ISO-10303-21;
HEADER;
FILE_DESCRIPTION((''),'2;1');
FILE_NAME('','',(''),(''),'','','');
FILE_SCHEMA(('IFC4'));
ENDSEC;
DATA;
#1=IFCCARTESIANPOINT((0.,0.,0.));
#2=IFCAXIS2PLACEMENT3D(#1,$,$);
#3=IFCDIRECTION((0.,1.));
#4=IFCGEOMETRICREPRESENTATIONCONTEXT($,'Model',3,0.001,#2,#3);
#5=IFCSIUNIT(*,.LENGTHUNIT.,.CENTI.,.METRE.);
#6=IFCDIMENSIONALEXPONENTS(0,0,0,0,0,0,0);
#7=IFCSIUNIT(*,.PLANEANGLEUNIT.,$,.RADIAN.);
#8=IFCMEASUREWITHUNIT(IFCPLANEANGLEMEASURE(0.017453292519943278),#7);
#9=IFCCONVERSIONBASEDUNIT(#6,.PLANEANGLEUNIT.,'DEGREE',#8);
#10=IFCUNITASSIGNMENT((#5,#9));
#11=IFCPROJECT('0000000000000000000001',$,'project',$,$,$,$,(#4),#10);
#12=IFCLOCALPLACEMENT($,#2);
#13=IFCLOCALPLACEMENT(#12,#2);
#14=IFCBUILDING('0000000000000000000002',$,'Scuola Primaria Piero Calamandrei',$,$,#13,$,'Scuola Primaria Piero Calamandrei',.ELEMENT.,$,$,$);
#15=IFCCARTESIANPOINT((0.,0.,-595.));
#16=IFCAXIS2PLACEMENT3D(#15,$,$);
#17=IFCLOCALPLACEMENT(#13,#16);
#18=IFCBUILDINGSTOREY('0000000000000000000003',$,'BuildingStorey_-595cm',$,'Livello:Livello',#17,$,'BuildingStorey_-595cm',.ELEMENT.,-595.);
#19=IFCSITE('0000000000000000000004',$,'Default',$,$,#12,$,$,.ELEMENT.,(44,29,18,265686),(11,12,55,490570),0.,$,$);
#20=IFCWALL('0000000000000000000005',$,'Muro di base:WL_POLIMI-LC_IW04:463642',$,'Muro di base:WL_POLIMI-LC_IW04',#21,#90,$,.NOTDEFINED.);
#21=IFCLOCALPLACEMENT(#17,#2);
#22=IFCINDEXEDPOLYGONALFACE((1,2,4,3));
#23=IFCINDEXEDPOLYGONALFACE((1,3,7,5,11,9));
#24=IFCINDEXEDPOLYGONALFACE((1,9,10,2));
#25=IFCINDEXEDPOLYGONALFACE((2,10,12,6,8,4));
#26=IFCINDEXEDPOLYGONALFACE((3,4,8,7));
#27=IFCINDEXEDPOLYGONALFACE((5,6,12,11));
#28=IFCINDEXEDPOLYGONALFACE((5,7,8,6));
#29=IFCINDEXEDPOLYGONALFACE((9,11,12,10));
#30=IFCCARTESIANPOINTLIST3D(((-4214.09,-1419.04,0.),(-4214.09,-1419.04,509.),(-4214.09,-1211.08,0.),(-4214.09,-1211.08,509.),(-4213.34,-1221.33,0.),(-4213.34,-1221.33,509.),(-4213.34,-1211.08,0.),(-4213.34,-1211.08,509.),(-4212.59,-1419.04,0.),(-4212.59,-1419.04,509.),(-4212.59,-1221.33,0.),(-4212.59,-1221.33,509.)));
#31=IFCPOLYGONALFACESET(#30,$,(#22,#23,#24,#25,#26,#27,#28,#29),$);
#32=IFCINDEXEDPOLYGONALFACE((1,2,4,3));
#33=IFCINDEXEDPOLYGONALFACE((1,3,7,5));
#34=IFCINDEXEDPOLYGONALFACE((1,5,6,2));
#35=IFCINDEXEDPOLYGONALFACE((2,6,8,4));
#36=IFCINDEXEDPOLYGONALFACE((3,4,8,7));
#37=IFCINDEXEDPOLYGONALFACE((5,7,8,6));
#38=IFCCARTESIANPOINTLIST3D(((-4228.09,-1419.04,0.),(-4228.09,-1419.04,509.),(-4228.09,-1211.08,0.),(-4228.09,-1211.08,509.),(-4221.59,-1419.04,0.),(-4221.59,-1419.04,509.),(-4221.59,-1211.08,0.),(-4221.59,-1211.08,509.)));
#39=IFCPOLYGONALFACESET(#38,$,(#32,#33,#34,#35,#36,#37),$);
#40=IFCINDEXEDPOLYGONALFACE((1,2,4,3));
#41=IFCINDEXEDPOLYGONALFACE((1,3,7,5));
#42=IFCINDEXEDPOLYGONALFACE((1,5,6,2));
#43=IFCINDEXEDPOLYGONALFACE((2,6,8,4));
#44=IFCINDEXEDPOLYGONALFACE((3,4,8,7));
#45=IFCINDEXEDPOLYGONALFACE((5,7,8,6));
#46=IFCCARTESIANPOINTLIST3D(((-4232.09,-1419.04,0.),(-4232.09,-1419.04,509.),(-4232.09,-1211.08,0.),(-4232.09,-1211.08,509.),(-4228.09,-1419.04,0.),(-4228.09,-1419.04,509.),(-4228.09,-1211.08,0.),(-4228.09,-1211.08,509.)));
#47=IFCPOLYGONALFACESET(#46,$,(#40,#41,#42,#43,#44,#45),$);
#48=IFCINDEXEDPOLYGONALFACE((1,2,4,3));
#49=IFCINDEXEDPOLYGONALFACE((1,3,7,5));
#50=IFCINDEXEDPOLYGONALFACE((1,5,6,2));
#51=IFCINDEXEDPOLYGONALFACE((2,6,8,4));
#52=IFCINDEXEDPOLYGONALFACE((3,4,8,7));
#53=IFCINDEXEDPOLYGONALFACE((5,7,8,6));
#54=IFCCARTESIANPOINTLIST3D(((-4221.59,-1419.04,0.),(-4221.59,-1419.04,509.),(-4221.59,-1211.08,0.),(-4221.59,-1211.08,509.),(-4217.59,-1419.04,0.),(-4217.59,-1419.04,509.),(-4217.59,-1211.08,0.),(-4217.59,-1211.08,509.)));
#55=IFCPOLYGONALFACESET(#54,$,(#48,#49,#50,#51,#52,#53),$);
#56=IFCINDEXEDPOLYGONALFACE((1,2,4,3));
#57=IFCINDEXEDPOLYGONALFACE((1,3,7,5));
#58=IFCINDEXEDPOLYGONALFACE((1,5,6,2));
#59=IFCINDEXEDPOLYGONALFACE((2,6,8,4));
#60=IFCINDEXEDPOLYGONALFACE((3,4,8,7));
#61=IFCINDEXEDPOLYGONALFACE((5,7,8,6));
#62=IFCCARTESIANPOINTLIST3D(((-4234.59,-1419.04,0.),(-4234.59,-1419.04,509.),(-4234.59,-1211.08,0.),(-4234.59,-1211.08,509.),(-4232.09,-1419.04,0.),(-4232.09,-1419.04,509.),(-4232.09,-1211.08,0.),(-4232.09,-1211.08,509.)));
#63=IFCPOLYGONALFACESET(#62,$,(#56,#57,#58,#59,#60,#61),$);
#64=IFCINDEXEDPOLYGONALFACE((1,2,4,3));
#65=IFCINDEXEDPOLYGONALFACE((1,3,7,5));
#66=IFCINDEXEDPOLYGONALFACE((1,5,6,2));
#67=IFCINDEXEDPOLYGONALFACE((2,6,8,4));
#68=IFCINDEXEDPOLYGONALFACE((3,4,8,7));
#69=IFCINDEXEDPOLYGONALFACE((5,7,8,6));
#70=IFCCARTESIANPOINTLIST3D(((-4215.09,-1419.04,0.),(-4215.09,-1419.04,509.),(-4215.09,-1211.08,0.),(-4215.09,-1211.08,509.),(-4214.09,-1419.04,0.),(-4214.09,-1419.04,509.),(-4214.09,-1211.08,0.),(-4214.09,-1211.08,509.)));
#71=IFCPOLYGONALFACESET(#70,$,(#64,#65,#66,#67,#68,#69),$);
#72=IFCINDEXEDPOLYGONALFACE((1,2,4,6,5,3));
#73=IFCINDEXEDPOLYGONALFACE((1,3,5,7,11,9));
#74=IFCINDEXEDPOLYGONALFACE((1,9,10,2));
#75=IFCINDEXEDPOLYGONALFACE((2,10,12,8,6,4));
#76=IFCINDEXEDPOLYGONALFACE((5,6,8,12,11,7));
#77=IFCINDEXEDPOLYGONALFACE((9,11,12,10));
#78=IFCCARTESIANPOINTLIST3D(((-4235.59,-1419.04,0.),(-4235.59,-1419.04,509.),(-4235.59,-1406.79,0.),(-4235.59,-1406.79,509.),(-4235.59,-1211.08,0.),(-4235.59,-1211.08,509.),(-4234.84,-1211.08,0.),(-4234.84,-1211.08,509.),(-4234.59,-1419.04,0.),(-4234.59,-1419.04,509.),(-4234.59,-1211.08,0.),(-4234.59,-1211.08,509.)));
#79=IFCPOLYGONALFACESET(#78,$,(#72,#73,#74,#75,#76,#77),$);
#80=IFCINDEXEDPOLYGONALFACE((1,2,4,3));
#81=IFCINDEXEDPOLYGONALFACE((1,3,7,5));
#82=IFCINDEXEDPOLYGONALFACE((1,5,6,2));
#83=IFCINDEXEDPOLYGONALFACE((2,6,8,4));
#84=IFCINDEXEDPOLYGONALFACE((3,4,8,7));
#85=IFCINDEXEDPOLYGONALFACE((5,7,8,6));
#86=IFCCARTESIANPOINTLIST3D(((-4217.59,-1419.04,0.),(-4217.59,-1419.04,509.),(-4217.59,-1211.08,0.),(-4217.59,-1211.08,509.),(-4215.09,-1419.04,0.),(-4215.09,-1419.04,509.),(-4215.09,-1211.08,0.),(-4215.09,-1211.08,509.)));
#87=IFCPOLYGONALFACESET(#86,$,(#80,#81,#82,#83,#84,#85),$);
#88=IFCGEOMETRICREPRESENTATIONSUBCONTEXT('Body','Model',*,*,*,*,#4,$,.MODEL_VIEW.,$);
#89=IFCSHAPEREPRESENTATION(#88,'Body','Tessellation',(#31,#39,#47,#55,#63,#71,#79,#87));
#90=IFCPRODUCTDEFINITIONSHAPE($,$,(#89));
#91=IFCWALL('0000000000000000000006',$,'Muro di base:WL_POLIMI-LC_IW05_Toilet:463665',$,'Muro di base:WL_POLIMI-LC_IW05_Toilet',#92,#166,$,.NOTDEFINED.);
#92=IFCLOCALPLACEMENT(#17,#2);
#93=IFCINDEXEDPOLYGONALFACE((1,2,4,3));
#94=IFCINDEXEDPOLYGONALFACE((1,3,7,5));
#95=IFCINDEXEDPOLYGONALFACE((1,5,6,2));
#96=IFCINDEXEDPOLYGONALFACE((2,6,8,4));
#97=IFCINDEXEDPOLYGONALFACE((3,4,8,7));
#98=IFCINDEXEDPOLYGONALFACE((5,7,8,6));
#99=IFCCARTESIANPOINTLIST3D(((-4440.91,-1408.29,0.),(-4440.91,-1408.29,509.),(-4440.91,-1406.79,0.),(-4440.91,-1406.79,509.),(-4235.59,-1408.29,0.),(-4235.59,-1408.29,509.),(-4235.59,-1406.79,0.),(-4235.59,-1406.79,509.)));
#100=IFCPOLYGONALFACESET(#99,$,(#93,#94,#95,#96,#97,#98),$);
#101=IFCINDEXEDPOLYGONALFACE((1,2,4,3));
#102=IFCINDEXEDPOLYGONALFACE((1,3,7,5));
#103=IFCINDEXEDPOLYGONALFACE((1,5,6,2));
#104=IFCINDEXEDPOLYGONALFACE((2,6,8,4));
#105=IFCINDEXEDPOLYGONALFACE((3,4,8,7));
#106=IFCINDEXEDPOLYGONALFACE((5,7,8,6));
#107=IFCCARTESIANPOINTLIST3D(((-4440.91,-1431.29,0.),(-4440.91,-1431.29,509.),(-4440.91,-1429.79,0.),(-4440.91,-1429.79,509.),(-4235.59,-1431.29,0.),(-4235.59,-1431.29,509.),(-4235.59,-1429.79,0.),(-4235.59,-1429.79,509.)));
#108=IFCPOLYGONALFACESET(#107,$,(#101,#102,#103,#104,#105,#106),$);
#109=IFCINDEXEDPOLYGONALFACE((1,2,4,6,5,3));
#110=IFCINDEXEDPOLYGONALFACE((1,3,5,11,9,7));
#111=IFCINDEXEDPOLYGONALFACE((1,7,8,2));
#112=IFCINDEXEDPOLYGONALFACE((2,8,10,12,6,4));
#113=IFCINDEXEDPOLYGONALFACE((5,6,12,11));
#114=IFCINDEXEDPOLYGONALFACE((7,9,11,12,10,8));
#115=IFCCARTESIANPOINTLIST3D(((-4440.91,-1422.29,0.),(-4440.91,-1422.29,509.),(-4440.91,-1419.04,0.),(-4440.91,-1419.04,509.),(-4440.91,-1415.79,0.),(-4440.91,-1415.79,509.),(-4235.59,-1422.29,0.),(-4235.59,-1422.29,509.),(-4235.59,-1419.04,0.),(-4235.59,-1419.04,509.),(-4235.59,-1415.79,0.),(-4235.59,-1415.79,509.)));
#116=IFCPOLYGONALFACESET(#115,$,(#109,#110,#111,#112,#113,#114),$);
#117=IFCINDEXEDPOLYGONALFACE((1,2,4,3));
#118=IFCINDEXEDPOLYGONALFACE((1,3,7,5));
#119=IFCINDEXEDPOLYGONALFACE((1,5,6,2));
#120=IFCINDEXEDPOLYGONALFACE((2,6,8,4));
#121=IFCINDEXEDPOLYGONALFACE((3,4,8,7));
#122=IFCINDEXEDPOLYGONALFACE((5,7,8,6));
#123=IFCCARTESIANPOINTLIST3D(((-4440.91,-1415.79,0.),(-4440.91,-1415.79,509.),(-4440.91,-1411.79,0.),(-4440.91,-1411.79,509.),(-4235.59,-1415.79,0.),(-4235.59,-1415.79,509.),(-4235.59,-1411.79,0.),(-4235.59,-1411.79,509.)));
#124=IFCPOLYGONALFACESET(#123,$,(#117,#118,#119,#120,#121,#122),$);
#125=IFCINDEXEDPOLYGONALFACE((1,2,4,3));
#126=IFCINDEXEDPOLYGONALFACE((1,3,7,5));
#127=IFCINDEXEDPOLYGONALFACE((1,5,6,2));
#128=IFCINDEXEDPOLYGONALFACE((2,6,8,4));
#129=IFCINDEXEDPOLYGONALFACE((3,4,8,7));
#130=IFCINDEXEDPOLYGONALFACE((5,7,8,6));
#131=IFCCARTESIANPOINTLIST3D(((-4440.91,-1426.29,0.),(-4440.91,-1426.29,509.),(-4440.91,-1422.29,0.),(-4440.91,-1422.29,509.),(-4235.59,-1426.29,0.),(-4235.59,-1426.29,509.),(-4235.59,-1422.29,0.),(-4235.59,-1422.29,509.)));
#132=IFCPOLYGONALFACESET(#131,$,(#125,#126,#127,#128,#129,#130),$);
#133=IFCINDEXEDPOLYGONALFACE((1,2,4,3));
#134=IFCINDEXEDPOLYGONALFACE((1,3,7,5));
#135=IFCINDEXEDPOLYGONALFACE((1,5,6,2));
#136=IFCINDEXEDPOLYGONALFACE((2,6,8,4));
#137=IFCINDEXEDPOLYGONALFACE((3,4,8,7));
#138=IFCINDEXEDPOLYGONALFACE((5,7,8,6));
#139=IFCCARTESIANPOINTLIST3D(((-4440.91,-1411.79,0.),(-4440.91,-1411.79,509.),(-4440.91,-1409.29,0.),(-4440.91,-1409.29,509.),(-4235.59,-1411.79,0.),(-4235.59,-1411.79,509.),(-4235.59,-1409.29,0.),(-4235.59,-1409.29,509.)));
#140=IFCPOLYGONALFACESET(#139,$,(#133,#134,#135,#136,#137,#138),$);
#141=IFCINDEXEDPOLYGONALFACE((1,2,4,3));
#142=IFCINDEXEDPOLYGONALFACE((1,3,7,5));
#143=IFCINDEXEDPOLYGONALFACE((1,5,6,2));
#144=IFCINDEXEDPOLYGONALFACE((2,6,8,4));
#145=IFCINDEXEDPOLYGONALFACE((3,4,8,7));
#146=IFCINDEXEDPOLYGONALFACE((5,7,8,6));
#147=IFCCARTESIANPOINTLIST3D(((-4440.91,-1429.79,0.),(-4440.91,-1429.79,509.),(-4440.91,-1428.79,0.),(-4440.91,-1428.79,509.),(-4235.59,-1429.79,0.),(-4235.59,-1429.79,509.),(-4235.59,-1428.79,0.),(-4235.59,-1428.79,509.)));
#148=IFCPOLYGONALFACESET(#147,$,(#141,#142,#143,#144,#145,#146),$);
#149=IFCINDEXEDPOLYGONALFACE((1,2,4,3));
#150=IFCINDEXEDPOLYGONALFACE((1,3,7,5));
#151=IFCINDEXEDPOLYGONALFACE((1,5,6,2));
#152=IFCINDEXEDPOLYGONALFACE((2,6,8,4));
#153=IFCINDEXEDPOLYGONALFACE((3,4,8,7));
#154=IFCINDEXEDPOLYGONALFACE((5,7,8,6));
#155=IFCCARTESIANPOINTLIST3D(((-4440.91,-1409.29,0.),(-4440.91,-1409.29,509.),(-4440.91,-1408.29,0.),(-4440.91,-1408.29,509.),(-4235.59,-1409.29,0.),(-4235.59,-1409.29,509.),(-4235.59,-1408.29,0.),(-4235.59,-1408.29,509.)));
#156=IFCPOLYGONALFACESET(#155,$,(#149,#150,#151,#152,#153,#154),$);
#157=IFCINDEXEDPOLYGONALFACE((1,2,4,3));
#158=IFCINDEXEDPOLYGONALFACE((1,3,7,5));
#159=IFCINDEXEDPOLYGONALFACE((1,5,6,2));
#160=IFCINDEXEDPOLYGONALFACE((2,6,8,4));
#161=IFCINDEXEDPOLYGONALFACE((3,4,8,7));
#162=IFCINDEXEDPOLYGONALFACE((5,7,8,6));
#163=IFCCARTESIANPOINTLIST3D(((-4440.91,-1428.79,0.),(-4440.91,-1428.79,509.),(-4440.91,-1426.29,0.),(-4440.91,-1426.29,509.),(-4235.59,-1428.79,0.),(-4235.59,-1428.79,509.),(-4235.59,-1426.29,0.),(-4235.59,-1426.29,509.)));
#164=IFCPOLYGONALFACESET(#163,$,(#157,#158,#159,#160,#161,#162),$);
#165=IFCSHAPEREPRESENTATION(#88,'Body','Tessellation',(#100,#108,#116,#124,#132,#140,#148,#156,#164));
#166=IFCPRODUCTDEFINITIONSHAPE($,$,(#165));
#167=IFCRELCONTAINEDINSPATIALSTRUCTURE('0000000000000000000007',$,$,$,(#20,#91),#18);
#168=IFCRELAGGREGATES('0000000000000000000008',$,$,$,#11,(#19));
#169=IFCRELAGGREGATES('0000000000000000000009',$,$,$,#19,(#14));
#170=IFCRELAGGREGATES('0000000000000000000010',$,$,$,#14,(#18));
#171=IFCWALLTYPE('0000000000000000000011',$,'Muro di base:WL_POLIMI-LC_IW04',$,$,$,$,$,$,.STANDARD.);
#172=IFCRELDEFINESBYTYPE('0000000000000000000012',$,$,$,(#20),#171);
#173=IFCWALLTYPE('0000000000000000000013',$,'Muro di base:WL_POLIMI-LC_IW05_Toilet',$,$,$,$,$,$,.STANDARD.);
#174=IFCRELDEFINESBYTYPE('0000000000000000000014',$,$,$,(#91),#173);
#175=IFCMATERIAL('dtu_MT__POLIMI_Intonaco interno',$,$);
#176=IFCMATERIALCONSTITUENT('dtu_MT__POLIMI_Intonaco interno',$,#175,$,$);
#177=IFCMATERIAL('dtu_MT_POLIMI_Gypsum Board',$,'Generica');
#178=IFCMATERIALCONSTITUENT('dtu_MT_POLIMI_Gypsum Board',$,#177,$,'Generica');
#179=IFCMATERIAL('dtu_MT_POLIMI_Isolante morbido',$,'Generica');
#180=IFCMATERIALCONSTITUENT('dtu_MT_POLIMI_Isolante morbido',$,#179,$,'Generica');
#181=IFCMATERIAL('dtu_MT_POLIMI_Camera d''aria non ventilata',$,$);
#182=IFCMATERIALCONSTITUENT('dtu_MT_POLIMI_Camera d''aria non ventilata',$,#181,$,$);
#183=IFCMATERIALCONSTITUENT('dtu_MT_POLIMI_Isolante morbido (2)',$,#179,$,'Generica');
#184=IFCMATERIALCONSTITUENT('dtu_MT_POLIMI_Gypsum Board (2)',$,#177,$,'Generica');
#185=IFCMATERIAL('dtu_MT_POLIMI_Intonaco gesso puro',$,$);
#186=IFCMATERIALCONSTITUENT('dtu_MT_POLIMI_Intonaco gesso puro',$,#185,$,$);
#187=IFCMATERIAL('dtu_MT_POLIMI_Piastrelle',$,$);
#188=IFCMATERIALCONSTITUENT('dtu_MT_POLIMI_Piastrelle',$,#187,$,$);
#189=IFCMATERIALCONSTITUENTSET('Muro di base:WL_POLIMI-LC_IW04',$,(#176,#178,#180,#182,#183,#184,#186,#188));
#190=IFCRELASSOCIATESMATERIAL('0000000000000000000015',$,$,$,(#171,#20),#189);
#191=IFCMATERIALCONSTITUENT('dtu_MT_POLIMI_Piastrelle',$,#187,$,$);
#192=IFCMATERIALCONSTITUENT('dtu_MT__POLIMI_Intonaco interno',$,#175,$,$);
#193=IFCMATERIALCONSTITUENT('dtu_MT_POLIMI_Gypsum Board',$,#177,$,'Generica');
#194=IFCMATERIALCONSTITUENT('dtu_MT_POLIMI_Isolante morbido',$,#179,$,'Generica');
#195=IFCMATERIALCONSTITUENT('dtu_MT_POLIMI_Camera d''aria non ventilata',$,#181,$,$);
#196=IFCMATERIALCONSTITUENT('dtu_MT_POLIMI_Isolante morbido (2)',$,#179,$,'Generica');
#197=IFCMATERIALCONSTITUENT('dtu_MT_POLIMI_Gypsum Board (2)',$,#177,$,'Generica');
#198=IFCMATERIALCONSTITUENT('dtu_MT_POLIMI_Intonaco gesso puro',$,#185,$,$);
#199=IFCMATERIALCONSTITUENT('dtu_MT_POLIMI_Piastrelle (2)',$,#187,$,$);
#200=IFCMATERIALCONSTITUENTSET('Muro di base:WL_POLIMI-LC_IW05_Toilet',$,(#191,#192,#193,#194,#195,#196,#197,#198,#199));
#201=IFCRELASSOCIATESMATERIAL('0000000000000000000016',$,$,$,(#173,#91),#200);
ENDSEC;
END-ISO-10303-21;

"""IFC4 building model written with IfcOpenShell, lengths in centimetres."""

from ifc_helpers import new_model, entity, si_unit, converted_unit, direction, frame, origin, place, context, subcontext, project, spatial, indexed_curve, outline, extrude, material, constituent, constituent_set, type_object, element, save


model = new_model("IFC4")

# Units and contexts
model_context = context("Model", 3, precision=0.001, world=origin(), true_north=direction((0.0, 1.0)))
body_context = subcontext(model_context, "Body", "Model", "MODEL_VIEW")
ifc_project = project(units=[si_unit("LENGTHUNIT", "METRE", prefix="CENTI"), converted_unit("PLANEANGLEUNIT", "DEGREE", entity("IfcPlaneAngleMeasure", 0.017453292519943278), si_unit("PLANEANGLEUNIT", "RADIAN"), dimensions=[0, 0, 0, 0, 0, 0, 0])], contexts=[model_context])

# Site, building, storey
site_placement = place(None, origin())
site = spatial("IfcSite", under=ifc_project, at=site_placement, Name="Default", CompositionType="ELEMENT", RefLatitude=(44, 29, 18, 265686), RefLongitude=(11, 12, 55, 490570), RefElevation=0.0)
building_placement = place(site_placement, origin())
building = spatial("IfcBuilding", under=site, at=building_placement, Name="Scuola Primaria Piero Calamandrei", LongName="Scuola Primaria Piero Calamandrei", CompositionType="ELEMENT")
storey_placement = place(building_placement, frame((0.0, 0.0, -595.0)))
storey = spatial("IfcBuildingStorey", under=building, at=storey_placement, Name="BuildingStorey_-595cm", ObjectType="Livello:Livello", LongName="BuildingStorey_-595cm", CompositionType="ELEMENT", Elevation=-595.0)

# Shared definitions
ifc_material_1 = material(Name="dtu_MT__POLIMI_Intonaco interno")

# Shared definitions
ifc_material_2 = material(Name="dtu_MT_POLIMI_Gypsum Board", Category="Generica")
ifc_material_3 = material(Name="dtu_MT_POLIMI_Isolante morbido", Category="Generica")
ifc_material_4 = material(Name="dtu_MT_POLIMI_Camera d'aria non ventilata")
ifc_material_5 = material(Name="dtu_MT_POLIMI_Intonaco gesso puro")

# Shared definitions
ifc_constituent_1 = constituent(ifc_material_1, Name="dtu_MT__POLIMI_Intonaco interno")
ifc_constituent_2 = constituent(ifc_material_2, Name="dtu_MT_POLIMI_Gypsum Board", Category="Generica")
ifc_constituent_3 = constituent(ifc_material_3, Name="dtu_MT_POLIMI_Isolante morbido", Category="Generica")
ifc_constituent_4 = constituent(ifc_material_4, Name="dtu_MT_POLIMI_Camera d'aria non ventilata")
ifc_constituent_5 = constituent(ifc_material_3, Name="dtu_MT_POLIMI_Isolante morbido (2)", Category="Generica")
ifc_constituent_6 = constituent(ifc_material_2, Name="dtu_MT_POLIMI_Gypsum Board (2)", Category="Generica")
ifc_constituent_7 = constituent(ifc_material_5, Name="dtu_MT_POLIMI_Intonaco gesso puro")
ifc_material_6 = material(Name="dtu_MT_POLIMI_Piastrelle")
ifc_constituent_8 = constituent(ifc_material_6, Name="dtu_MT_POLIMI_Piastrelle")
ifc_constituent_set_1 = constituent_set(constituents=[ifc_constituent_1, ifc_constituent_2, ifc_constituent_3, ifc_constituent_4, ifc_constituent_5, ifc_constituent_6, ifc_constituent_7, ifc_constituent_8], Name="Muro di base:WL_POLIMI-LC_IW04")
wall_type_1 = type_object("IfcWallType", Name="Muro di base:WL_POLIMI-LC_IW04", PredefinedType="STANDARD", material=ifc_constituent_set_1)

# Wall
wall_1_placement = place(storey_placement, frame((-4224.09, -1419.04, 0.0), z_axis=(0.0, 0.0, 1.0), x_axis=(0.0, 1.0, 0.0)))
element("IfcWall", 1, at=wall_1_placement, inside=storey, type_object=wall_type_1, material=ifc_constituent_set_1, Name="Muro di base:WL_POLIMI-LC_IW04:463642", ObjectType="Muro di base:WL_POLIMI-LC_IW04", PredefinedType="NOTDEFINED", context=body_context, shape_type="SweptSolid", body=[
    extrude(outline(indexed_curve([(-0.75, 62.49), (-0.75, -135.22), (0.75, -135.22), (0.75, 72.74), (0.0, 72.74), (0.0, 62.49), (-0.75, 62.49)], self_intersect=False)), frame((135.22, -10.75, 0.0), z_axis=(0.0, 0.0, -1.0), x_axis=(0.0, 1.0, 0.0)), (0.0, 0.0, -1.0), 509.0),
    extrude(outline(indexed_curve([(-103.98, -3.25), (103.98, -3.25), (103.98, 3.25), (-103.98, 3.25), (-103.98, -3.25)], self_intersect=False)), frame((103.98, 0.75, 0.0)), (0.0, 0.0, 1.0), 509.0),
    extrude(outline(indexed_curve([(-103.98, -2.0), (103.98, -2.0), (103.98, 2.0), (-103.98, 2.0), (-103.98, -2.0)], self_intersect=False)), frame((103.98, 6.0, 0.0)), (0.0, 0.0, 1.0), 509.0),
    extrude(outline(indexed_curve([(-103.98, -2.0), (103.98, -2.0), (103.98, 2.0), (-103.98, 2.0), (-103.98, -2.0)], self_intersect=False)), frame((103.98, -4.5, 0.0)), (0.0, 0.0, 1.0), 509.0),
    extrude(outline(indexed_curve([(-103.98, -1.25), (103.98, -1.25), (103.98, 1.25), (-103.98, 1.25), (-103.98, -1.25)], self_intersect=False)), frame((103.98, 9.25, 0.0)), (0.0, 0.0, 1.0), 509.0),
    extrude(outline(indexed_curve([(-103.98, -0.5), (103.98, -0.5), (103.98, 0.5), (-103.98, 0.5), (-103.98, -0.5)], self_intersect=False)), frame((103.98, -9.5, 0.0)), (0.0, 0.0, 1.0), 509.0),
    extrude(outline(indexed_curve([(93.77, -0.46), (106.02, -0.46), (106.02, 0.54), (-101.94, 0.54), (-101.94, 0.29), (-101.94, -0.46), (93.77, -0.46)], self_intersect=False)), frame((106.02, 11.04, 0.0), z_axis=(0.0, 0.0, 1.0), x_axis=(-1.0, 0.0, 0.0)), (0.0, 0.0, 1.0), 509.0),
    extrude(outline(indexed_curve([(-103.98, -1.25), (103.98, -1.25), (103.98, 1.25), (-103.98, 1.25), (-103.98, -1.25)], self_intersect=False)), frame((103.98, -7.75, 0.0)), (0.0, 0.0, 1.0), 509.0),
])

# Shared definitions
ifc_constituent_9 = constituent(ifc_material_6, Name="dtu_MT_POLIMI_Piastrelle")
ifc_constituent_10 = constituent(ifc_material_1, Name="dtu_MT__POLIMI_Intonaco interno")
ifc_constituent_11 = constituent(ifc_material_2, Name="dtu_MT_POLIMI_Gypsum Board", Category="Generica")
ifc_constituent_12 = constituent(ifc_material_3, Name="dtu_MT_POLIMI_Isolante morbido", Category="Generica")
ifc_constituent_13 = constituent(ifc_material_4, Name="dtu_MT_POLIMI_Camera d'aria non ventilata")
ifc_constituent_14 = constituent(ifc_material_3, Name="dtu_MT_POLIMI_Isolante morbido (2)", Category="Generica")
ifc_constituent_15 = constituent(ifc_material_2, Name="dtu_MT_POLIMI_Gypsum Board (2)", Category="Generica")
ifc_constituent_16 = constituent(ifc_material_5, Name="dtu_MT_POLIMI_Intonaco gesso puro")
ifc_constituent_17 = constituent(ifc_material_6, Name="dtu_MT_POLIMI_Piastrelle (2)")
ifc_constituent_set_2 = constituent_set(constituents=[ifc_constituent_9, ifc_constituent_10, ifc_constituent_11, ifc_constituent_12, ifc_constituent_13, ifc_constituent_14, ifc_constituent_15, ifc_constituent_16, ifc_constituent_17], Name="Muro di base:WL_POLIMI-LC_IW05_Toilet")
wall_type_2 = type_object("IfcWallType", Name="Muro di base:WL_POLIMI-LC_IW05_Toilet", PredefinedType="STANDARD", material=ifc_constituent_set_2)

# Wall
wall_2_placement = place(storey_placement, frame((-4440.91, -1419.04, 0.0)))
element("IfcWall", 2, at=wall_2_placement, inside=storey, type_object=wall_type_2, material=ifc_constituent_set_2, Name="Muro di base:WL_POLIMI-LC_IW05_Toilet:463665", ObjectType="Muro di base:WL_POLIMI-LC_IW05_Toilet", PredefinedType="NOTDEFINED", context=body_context, shape_type="SweptSolid", body=[
    extrude(outline(indexed_curve([(-0.75, -102.66), (0.75, -102.66), (0.75, 102.66), (-0.75, 102.66), (-0.75, -102.66)], self_intersect=False)), frame((102.66, 11.5, 0.0), z_axis=(0.0, 0.0, 1.0), x_axis=(0.0, -1.0, 0.0)), (0.0, 0.0, 1.0), 509.0),
    extrude(outline(indexed_curve([(-0.75, -102.66), (0.75, -102.66), (0.75, 102.66), (-0.75, 102.66), (-0.75, -102.66)], self_intersect=False)), frame((102.66, -11.5, 0.0), z_axis=(0.0, 0.0, 1.0), x_axis=(0.0, 1.0, 0.0)), (0.0, 0.0, 1.0), 509.0),
    extrude(outline(indexed_curve([(-102.66, -3.25), (102.66, -3.25), (102.66, 0.0), (102.66, 3.25), (-102.66, 3.25), (-102.66, 0.0), (-102.66, -3.25)], self_intersect=False)), frame((102.66, 0.0, 0.0)), (0.0, 0.0, 1.0), 509.0),
    extrude(outline(indexed_curve([(-102.66, -2.0), (102.66, -2.0), (102.66, 2.0), (-102.66, 2.0), (-102.66, -2.0)], self_intersect=False)), frame((102.66, 5.25, 0.0)), (0.0, 0.0, 1.0), 509.0),
    extrude(outline(indexed_curve([(-102.66, -2.0), (102.66, -2.0), (102.66, 2.0), (-102.66, 2.0), (-102.66, -2.0)], self_intersect=False)), frame((102.66, -5.25, 0.0)), (0.0, 0.0, 1.0), 509.0),
    extrude(outline(indexed_curve([(-102.66, -1.25), (102.66, -1.25), (102.66, 1.25), (-102.66, 1.25), (-102.66, -1.25)], self_intersect=False)), frame((102.66, 8.5, 0.0)), (0.0, 0.0, 1.0), 509.0),
    extrude(outline(indexed_curve([(-102.66, -0.5), (102.66, -0.5), (102.66, 0.5), (-102.66, 0.5), (-102.66, -0.5)], self_intersect=False)), frame((102.66, -10.25, 0.0)), (0.0, 0.0, 1.0), 509.0),
    extrude(outline(indexed_curve([(-102.66, -0.5), (102.66, -0.5), (102.66, 0.5), (-102.66, 0.5), (-102.66, -0.5)], self_intersect=False)), frame((102.66, 10.25, 0.0)), (0.0, 0.0, 1.0), 509.0),
    extrude(outline(indexed_curve([(-102.66, -1.25), (102.66, -1.25), (102.66, 1.25), (-102.66, 1.25), (-102.66, -1.25)], self_intersect=False)), frame((102.66, -8.5, 0.0)), (0.0, 0.0, 1.0), 509.0),
])

save(model, "model.ifc")
